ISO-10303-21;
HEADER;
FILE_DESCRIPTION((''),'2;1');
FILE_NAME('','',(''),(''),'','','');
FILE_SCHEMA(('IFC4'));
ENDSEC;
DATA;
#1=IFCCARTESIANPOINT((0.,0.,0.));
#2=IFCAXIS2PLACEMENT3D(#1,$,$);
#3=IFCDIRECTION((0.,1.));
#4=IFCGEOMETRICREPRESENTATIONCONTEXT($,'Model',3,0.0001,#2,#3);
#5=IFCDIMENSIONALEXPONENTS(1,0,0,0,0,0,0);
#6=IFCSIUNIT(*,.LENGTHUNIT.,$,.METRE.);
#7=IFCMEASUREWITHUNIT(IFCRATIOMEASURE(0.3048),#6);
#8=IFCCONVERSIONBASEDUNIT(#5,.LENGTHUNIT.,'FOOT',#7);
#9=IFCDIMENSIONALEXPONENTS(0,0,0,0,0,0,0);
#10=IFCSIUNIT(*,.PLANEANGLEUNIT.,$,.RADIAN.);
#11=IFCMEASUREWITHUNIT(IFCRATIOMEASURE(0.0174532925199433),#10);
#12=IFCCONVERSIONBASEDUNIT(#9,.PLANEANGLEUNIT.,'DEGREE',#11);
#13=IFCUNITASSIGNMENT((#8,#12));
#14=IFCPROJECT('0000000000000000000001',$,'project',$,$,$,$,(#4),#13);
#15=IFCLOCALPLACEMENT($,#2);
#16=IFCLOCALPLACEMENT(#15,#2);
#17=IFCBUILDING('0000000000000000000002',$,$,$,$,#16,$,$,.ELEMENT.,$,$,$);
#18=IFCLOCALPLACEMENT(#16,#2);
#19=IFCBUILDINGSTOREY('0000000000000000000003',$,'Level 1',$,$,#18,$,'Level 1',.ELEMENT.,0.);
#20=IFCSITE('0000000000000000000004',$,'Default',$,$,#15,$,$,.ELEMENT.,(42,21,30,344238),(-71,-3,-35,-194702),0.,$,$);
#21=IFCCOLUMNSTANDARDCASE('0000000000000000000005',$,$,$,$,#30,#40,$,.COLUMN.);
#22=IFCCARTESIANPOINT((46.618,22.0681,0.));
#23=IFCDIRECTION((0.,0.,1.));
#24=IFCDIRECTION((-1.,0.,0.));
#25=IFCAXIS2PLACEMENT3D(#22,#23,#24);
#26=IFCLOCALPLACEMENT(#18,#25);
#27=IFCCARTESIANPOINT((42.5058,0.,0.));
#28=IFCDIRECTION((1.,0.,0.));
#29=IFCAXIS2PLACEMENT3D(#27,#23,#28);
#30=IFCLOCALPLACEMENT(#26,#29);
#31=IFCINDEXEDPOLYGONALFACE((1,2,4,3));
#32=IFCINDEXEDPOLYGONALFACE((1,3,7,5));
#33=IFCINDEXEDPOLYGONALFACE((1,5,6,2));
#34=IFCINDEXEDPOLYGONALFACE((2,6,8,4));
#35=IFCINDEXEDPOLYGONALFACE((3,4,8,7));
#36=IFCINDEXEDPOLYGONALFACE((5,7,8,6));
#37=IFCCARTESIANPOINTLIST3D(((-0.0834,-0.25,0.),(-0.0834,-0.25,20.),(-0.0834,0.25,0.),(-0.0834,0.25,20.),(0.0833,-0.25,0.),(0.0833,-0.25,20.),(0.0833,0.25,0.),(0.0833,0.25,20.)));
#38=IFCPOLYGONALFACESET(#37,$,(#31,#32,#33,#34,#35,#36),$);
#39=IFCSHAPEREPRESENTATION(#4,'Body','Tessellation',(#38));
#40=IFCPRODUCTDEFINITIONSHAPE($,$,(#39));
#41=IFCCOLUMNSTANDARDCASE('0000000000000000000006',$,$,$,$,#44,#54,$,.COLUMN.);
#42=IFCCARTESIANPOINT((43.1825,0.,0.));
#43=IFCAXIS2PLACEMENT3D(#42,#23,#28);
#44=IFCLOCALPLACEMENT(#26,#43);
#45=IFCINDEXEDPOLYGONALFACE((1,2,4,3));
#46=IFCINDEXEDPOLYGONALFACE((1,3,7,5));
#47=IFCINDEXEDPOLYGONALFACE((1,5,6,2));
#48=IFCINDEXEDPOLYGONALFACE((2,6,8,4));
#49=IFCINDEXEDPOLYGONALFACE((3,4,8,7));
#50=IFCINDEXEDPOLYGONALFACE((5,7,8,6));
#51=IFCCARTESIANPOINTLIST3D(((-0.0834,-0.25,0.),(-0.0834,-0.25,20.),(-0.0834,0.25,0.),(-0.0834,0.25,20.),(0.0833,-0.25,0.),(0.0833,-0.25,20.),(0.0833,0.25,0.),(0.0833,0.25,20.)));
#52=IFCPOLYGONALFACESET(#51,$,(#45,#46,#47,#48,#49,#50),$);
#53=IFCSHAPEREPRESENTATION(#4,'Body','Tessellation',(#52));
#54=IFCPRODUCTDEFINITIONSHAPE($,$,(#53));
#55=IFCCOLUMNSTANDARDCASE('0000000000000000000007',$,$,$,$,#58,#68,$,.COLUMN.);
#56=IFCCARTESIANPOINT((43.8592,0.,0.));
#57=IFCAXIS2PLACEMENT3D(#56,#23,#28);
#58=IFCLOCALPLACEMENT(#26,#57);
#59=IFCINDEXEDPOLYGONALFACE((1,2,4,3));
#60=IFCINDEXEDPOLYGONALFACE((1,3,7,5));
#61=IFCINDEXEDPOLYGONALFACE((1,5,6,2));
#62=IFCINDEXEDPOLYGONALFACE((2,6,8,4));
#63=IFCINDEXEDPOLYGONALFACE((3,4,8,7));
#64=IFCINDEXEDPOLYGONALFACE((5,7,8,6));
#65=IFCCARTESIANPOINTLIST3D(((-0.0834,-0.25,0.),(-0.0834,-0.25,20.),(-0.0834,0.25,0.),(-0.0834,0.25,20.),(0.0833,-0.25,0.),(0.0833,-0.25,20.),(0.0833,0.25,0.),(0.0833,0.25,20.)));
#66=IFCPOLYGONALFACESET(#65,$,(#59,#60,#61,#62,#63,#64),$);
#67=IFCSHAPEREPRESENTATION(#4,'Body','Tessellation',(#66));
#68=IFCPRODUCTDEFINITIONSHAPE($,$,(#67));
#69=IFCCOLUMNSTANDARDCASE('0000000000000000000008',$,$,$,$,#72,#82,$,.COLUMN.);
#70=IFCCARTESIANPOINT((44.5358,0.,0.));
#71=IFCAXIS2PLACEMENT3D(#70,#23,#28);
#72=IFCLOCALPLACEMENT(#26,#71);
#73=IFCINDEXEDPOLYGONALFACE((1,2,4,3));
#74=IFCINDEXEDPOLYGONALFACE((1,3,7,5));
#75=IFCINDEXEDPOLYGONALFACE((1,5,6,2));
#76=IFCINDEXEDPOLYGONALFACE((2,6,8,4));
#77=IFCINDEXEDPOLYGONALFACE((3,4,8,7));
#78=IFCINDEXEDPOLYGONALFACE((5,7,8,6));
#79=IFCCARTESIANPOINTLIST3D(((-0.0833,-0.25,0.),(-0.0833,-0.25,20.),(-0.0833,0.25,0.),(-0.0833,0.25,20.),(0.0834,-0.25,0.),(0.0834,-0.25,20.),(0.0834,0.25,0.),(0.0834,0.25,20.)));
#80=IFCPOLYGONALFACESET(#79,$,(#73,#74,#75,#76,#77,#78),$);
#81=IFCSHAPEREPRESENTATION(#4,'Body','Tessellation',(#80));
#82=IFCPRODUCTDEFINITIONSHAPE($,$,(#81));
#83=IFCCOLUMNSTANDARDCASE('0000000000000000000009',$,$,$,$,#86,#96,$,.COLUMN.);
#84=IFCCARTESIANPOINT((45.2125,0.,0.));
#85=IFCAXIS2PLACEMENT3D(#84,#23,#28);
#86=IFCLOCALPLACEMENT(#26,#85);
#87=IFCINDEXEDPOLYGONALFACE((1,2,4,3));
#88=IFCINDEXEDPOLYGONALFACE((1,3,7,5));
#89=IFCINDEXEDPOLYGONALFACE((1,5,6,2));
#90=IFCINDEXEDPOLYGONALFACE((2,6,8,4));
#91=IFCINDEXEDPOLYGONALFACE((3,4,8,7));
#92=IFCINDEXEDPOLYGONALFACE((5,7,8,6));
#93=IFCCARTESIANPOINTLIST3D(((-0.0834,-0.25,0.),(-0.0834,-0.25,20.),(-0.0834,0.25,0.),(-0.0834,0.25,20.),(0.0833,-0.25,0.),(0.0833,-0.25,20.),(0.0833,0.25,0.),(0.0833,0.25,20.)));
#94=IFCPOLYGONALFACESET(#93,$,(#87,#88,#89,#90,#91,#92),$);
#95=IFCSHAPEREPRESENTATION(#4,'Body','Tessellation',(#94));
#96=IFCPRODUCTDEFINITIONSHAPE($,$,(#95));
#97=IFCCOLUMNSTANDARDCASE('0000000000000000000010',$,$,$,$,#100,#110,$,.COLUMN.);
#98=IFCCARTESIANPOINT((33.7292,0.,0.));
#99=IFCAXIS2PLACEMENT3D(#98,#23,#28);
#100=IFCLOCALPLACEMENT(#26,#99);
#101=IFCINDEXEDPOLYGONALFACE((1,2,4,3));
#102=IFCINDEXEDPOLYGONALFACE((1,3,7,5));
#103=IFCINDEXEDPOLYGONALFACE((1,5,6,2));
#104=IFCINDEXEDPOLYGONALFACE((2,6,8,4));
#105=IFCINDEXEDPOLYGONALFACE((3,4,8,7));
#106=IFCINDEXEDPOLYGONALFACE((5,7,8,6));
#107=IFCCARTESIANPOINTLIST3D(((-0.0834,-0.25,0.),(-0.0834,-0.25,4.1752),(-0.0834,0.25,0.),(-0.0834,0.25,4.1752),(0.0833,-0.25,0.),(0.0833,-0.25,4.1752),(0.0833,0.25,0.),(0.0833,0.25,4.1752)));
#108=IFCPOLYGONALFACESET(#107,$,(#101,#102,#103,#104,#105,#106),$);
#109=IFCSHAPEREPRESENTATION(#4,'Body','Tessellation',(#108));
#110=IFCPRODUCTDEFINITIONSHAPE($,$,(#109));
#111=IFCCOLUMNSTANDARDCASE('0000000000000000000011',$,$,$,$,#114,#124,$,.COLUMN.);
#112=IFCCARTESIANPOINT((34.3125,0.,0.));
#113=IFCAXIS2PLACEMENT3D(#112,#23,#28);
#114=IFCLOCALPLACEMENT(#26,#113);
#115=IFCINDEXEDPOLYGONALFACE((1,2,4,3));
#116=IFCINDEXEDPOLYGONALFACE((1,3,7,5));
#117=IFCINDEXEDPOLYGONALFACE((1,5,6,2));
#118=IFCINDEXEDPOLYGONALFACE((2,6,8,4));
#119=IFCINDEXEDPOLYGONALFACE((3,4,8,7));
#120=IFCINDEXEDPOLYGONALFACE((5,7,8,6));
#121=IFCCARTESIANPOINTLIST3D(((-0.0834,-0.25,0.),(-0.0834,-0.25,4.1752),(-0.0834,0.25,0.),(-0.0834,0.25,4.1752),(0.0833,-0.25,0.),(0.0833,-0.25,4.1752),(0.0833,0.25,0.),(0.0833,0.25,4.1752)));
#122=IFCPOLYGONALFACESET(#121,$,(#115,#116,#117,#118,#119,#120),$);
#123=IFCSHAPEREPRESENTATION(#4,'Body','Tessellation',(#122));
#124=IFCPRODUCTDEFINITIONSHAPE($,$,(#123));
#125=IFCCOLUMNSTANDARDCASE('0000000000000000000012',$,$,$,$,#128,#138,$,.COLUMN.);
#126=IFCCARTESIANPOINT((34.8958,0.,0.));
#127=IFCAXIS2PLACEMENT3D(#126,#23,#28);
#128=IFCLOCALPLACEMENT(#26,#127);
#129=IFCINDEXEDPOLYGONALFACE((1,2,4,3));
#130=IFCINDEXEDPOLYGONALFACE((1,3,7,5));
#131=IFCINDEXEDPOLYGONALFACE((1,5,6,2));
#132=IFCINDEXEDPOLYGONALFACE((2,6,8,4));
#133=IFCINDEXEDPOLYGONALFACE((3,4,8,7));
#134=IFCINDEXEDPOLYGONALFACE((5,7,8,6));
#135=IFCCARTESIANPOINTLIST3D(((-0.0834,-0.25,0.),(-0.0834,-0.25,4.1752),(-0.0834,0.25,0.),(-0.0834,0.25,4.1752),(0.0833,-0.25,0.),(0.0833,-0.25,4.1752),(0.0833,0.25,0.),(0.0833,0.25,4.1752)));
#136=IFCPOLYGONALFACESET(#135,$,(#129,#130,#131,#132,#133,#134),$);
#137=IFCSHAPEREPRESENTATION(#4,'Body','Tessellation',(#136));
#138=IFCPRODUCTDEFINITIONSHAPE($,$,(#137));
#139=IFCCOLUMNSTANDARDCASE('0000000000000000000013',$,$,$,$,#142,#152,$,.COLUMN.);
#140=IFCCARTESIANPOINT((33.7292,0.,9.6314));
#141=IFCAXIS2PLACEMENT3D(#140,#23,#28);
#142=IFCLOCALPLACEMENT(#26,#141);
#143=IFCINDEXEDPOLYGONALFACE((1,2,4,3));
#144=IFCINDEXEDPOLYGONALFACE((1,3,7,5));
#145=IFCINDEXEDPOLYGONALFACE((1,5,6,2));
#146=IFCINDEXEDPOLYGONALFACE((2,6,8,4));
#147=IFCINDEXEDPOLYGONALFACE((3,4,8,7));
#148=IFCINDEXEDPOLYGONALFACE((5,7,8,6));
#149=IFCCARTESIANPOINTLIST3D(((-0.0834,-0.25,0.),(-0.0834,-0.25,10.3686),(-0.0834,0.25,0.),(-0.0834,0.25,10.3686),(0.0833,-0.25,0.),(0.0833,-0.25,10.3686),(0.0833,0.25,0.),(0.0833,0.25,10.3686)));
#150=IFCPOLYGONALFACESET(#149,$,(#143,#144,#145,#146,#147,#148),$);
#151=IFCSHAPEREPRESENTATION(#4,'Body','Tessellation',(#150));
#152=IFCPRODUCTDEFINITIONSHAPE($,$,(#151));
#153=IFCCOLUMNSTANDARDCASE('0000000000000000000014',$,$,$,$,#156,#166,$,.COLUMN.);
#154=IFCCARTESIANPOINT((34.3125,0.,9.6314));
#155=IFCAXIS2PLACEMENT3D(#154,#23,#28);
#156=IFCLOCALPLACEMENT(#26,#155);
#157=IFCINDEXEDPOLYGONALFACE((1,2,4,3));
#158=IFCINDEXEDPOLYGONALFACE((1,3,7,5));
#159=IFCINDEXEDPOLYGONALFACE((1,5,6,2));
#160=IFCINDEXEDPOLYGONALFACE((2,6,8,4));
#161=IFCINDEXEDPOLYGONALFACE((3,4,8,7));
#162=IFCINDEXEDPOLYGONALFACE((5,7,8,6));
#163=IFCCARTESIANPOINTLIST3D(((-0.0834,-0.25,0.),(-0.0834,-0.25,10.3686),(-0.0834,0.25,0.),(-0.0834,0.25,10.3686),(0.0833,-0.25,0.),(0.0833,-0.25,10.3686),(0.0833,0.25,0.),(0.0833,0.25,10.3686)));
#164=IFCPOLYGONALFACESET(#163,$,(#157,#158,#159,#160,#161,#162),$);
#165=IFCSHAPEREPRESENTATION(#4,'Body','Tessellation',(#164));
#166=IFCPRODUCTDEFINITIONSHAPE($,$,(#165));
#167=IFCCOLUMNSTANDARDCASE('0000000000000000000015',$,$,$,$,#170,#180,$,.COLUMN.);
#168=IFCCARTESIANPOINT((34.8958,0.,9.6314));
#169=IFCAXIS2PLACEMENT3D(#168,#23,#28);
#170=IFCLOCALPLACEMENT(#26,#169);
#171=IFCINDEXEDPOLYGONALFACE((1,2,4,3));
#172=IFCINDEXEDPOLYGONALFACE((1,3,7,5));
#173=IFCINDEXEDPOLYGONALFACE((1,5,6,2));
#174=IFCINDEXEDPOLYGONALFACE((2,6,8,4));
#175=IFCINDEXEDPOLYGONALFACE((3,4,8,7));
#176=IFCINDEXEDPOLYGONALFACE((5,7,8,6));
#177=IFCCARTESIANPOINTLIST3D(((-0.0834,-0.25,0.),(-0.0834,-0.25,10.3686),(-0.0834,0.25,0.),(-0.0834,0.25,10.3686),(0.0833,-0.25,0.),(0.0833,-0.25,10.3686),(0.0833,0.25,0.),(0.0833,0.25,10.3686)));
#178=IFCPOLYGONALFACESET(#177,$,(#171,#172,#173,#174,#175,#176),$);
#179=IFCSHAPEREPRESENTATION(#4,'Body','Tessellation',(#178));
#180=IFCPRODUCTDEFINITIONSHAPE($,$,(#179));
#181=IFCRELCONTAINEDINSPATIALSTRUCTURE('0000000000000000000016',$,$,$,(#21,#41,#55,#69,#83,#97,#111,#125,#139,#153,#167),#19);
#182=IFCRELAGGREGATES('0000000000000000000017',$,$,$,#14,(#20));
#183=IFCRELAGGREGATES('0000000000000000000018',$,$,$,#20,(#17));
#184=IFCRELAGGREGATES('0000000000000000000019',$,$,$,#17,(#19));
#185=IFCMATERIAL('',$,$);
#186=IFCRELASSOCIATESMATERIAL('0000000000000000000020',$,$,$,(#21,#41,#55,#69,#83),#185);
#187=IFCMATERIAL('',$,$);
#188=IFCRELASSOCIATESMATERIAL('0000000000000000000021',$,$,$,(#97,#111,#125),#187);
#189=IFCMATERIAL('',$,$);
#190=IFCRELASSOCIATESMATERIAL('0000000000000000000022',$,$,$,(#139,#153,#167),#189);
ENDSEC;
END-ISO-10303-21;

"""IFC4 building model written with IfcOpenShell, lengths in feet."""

from ifc_helpers import new_model, entity, si_unit, converted_unit, direction, frame, origin, place, context, project, spatial, rectangle, extrude, material, element, save


model = new_model("IFC4")

# Units and contexts
model_context = context("Model", 3, precision=0.0001, world=origin(), true_north=direction((0.0, 1.0)))
ifc_project = project(units=[converted_unit("LENGTHUNIT", "FOOT", entity("IfcRatioMeasure", 0.3048), si_unit("LENGTHUNIT", "METRE"), dimensions=[1, 0, 0, 0, 0, 0, 0]), converted_unit("PLANEANGLEUNIT", "DEGREE", entity("IfcRatioMeasure", 0.0174532925199433), si_unit("PLANEANGLEUNIT", "RADIAN"), dimensions=[0, 0, 0, 0, 0, 0, 0])], contexts=[model_context])

# Site, building, storey
site_placement = place(None, origin())
site = spatial("IfcSite", under=ifc_project, at=site_placement, Name="Default", CompositionType="ELEMENT", RefLatitude=(42, 21, 30, 344238), RefLongitude=(-71, -3, -35, -194702), RefElevation=0.0)
building_placement = place(site_placement, origin())
building = spatial("IfcBuilding", under=site, at=building_placement, CompositionType="ELEMENT")
storey_placement = place(building_placement, origin())
storey = spatial("IfcBuildingStorey", under=building, at=storey_placement, Name="Level 1", LongName="Level 1", CompositionType="ELEMENT", Elevation=0.0)

# Columns
placement = place(storey_placement, frame((46.618, 22.0681, 0.0), z_axis=(0.0, 0.0, 1.0), x_axis=(-1.0, 0.0, 0.0)))
ifc_material_1 = material(Name="")
for number, where, z_axis, x_axis in (
    (1, (42.5058, 0.0, 0.0), (0.0, 0.0, 1.0), (1.0, 0.0, 0.0)),
    (2, (43.1825, 0.0, 0.0), (0.0, 0.0, 1.0), (1.0, 0.0, 0.0)),
    (3, (43.8592, 0.0, 0.0), (0.0, 0.0, 1.0), (1.0, 0.0, 0.0)),
    (4, (44.5358, 0.0, 0.0), (0.0, 0.0, 1.0), (1.0, 0.0, 0.0)),
    (5, (45.2125, 0.0, 0.0), (0.0, 0.0, 1.0), (1.0, 0.0, 0.0)),
):
    element("IfcColumnStandardCase", number, at=place(placement, frame(where, z_axis=z_axis, x_axis=x_axis)), inside=storey, material=ifc_material_1, PredefinedType="COLUMN", context=model_context, shape_type="SweptSolid", body=[
        extrude(rectangle(XDim=0.1667, YDim=0.5), origin(), (0.0, 0.0, 1.0), 20.0),
    ])
ifc_material_2 = material(Name="")
for number, where, z_axis, x_axis in (
    (6, (33.7292, 0.0, 0.0), (0.0, 0.0, 1.0), (1.0, 0.0, 0.0)),
    (7, (34.3125, 0.0, 0.0), (0.0, 0.0, 1.0), (1.0, 0.0, 0.0)),
    (8, (34.8958, 0.0, 0.0), (0.0, 0.0, 1.0), (1.0, 0.0, 0.0)),
):
    element("IfcColumnStandardCase", number, at=place(placement, frame(where, z_axis=z_axis, x_axis=x_axis)), inside=storey, material=ifc_material_2, PredefinedType="COLUMN", context=model_context, shape_type="SweptSolid", body=[
        extrude(rectangle(XDim=0.1667, YDim=0.5), origin(), (0.0, 0.0, 1.0), 4.1752),
    ])
ifc_material_3 = material(Name="")
for number, where, z_axis, x_axis in (
    (9, (33.7292, 0.0, 9.6314), (0.0, 0.0, 1.0), (1.0, 0.0, 0.0)),
    (10, (34.3125, 0.0, 9.6314), (0.0, 0.0, 1.0), (1.0, 0.0, 0.0)),
    (11, (34.8958, 0.0, 9.6314), (0.0, 0.0, 1.0), (1.0, 0.0, 0.0)),
):
    element("IfcColumnStandardCase", number, at=place(placement, frame(where, z_axis=z_axis, x_axis=x_axis)), inside=storey, material=ifc_material_3, PredefinedType="COLUMN", context=model_context, shape_type="SweptSolid", body=[
        extrude(rectangle(XDim=0.1667, YDim=0.5), origin(), (0.0, 0.0, 1.0), 10.3686),
    ])

save(model, "model.ifc")
